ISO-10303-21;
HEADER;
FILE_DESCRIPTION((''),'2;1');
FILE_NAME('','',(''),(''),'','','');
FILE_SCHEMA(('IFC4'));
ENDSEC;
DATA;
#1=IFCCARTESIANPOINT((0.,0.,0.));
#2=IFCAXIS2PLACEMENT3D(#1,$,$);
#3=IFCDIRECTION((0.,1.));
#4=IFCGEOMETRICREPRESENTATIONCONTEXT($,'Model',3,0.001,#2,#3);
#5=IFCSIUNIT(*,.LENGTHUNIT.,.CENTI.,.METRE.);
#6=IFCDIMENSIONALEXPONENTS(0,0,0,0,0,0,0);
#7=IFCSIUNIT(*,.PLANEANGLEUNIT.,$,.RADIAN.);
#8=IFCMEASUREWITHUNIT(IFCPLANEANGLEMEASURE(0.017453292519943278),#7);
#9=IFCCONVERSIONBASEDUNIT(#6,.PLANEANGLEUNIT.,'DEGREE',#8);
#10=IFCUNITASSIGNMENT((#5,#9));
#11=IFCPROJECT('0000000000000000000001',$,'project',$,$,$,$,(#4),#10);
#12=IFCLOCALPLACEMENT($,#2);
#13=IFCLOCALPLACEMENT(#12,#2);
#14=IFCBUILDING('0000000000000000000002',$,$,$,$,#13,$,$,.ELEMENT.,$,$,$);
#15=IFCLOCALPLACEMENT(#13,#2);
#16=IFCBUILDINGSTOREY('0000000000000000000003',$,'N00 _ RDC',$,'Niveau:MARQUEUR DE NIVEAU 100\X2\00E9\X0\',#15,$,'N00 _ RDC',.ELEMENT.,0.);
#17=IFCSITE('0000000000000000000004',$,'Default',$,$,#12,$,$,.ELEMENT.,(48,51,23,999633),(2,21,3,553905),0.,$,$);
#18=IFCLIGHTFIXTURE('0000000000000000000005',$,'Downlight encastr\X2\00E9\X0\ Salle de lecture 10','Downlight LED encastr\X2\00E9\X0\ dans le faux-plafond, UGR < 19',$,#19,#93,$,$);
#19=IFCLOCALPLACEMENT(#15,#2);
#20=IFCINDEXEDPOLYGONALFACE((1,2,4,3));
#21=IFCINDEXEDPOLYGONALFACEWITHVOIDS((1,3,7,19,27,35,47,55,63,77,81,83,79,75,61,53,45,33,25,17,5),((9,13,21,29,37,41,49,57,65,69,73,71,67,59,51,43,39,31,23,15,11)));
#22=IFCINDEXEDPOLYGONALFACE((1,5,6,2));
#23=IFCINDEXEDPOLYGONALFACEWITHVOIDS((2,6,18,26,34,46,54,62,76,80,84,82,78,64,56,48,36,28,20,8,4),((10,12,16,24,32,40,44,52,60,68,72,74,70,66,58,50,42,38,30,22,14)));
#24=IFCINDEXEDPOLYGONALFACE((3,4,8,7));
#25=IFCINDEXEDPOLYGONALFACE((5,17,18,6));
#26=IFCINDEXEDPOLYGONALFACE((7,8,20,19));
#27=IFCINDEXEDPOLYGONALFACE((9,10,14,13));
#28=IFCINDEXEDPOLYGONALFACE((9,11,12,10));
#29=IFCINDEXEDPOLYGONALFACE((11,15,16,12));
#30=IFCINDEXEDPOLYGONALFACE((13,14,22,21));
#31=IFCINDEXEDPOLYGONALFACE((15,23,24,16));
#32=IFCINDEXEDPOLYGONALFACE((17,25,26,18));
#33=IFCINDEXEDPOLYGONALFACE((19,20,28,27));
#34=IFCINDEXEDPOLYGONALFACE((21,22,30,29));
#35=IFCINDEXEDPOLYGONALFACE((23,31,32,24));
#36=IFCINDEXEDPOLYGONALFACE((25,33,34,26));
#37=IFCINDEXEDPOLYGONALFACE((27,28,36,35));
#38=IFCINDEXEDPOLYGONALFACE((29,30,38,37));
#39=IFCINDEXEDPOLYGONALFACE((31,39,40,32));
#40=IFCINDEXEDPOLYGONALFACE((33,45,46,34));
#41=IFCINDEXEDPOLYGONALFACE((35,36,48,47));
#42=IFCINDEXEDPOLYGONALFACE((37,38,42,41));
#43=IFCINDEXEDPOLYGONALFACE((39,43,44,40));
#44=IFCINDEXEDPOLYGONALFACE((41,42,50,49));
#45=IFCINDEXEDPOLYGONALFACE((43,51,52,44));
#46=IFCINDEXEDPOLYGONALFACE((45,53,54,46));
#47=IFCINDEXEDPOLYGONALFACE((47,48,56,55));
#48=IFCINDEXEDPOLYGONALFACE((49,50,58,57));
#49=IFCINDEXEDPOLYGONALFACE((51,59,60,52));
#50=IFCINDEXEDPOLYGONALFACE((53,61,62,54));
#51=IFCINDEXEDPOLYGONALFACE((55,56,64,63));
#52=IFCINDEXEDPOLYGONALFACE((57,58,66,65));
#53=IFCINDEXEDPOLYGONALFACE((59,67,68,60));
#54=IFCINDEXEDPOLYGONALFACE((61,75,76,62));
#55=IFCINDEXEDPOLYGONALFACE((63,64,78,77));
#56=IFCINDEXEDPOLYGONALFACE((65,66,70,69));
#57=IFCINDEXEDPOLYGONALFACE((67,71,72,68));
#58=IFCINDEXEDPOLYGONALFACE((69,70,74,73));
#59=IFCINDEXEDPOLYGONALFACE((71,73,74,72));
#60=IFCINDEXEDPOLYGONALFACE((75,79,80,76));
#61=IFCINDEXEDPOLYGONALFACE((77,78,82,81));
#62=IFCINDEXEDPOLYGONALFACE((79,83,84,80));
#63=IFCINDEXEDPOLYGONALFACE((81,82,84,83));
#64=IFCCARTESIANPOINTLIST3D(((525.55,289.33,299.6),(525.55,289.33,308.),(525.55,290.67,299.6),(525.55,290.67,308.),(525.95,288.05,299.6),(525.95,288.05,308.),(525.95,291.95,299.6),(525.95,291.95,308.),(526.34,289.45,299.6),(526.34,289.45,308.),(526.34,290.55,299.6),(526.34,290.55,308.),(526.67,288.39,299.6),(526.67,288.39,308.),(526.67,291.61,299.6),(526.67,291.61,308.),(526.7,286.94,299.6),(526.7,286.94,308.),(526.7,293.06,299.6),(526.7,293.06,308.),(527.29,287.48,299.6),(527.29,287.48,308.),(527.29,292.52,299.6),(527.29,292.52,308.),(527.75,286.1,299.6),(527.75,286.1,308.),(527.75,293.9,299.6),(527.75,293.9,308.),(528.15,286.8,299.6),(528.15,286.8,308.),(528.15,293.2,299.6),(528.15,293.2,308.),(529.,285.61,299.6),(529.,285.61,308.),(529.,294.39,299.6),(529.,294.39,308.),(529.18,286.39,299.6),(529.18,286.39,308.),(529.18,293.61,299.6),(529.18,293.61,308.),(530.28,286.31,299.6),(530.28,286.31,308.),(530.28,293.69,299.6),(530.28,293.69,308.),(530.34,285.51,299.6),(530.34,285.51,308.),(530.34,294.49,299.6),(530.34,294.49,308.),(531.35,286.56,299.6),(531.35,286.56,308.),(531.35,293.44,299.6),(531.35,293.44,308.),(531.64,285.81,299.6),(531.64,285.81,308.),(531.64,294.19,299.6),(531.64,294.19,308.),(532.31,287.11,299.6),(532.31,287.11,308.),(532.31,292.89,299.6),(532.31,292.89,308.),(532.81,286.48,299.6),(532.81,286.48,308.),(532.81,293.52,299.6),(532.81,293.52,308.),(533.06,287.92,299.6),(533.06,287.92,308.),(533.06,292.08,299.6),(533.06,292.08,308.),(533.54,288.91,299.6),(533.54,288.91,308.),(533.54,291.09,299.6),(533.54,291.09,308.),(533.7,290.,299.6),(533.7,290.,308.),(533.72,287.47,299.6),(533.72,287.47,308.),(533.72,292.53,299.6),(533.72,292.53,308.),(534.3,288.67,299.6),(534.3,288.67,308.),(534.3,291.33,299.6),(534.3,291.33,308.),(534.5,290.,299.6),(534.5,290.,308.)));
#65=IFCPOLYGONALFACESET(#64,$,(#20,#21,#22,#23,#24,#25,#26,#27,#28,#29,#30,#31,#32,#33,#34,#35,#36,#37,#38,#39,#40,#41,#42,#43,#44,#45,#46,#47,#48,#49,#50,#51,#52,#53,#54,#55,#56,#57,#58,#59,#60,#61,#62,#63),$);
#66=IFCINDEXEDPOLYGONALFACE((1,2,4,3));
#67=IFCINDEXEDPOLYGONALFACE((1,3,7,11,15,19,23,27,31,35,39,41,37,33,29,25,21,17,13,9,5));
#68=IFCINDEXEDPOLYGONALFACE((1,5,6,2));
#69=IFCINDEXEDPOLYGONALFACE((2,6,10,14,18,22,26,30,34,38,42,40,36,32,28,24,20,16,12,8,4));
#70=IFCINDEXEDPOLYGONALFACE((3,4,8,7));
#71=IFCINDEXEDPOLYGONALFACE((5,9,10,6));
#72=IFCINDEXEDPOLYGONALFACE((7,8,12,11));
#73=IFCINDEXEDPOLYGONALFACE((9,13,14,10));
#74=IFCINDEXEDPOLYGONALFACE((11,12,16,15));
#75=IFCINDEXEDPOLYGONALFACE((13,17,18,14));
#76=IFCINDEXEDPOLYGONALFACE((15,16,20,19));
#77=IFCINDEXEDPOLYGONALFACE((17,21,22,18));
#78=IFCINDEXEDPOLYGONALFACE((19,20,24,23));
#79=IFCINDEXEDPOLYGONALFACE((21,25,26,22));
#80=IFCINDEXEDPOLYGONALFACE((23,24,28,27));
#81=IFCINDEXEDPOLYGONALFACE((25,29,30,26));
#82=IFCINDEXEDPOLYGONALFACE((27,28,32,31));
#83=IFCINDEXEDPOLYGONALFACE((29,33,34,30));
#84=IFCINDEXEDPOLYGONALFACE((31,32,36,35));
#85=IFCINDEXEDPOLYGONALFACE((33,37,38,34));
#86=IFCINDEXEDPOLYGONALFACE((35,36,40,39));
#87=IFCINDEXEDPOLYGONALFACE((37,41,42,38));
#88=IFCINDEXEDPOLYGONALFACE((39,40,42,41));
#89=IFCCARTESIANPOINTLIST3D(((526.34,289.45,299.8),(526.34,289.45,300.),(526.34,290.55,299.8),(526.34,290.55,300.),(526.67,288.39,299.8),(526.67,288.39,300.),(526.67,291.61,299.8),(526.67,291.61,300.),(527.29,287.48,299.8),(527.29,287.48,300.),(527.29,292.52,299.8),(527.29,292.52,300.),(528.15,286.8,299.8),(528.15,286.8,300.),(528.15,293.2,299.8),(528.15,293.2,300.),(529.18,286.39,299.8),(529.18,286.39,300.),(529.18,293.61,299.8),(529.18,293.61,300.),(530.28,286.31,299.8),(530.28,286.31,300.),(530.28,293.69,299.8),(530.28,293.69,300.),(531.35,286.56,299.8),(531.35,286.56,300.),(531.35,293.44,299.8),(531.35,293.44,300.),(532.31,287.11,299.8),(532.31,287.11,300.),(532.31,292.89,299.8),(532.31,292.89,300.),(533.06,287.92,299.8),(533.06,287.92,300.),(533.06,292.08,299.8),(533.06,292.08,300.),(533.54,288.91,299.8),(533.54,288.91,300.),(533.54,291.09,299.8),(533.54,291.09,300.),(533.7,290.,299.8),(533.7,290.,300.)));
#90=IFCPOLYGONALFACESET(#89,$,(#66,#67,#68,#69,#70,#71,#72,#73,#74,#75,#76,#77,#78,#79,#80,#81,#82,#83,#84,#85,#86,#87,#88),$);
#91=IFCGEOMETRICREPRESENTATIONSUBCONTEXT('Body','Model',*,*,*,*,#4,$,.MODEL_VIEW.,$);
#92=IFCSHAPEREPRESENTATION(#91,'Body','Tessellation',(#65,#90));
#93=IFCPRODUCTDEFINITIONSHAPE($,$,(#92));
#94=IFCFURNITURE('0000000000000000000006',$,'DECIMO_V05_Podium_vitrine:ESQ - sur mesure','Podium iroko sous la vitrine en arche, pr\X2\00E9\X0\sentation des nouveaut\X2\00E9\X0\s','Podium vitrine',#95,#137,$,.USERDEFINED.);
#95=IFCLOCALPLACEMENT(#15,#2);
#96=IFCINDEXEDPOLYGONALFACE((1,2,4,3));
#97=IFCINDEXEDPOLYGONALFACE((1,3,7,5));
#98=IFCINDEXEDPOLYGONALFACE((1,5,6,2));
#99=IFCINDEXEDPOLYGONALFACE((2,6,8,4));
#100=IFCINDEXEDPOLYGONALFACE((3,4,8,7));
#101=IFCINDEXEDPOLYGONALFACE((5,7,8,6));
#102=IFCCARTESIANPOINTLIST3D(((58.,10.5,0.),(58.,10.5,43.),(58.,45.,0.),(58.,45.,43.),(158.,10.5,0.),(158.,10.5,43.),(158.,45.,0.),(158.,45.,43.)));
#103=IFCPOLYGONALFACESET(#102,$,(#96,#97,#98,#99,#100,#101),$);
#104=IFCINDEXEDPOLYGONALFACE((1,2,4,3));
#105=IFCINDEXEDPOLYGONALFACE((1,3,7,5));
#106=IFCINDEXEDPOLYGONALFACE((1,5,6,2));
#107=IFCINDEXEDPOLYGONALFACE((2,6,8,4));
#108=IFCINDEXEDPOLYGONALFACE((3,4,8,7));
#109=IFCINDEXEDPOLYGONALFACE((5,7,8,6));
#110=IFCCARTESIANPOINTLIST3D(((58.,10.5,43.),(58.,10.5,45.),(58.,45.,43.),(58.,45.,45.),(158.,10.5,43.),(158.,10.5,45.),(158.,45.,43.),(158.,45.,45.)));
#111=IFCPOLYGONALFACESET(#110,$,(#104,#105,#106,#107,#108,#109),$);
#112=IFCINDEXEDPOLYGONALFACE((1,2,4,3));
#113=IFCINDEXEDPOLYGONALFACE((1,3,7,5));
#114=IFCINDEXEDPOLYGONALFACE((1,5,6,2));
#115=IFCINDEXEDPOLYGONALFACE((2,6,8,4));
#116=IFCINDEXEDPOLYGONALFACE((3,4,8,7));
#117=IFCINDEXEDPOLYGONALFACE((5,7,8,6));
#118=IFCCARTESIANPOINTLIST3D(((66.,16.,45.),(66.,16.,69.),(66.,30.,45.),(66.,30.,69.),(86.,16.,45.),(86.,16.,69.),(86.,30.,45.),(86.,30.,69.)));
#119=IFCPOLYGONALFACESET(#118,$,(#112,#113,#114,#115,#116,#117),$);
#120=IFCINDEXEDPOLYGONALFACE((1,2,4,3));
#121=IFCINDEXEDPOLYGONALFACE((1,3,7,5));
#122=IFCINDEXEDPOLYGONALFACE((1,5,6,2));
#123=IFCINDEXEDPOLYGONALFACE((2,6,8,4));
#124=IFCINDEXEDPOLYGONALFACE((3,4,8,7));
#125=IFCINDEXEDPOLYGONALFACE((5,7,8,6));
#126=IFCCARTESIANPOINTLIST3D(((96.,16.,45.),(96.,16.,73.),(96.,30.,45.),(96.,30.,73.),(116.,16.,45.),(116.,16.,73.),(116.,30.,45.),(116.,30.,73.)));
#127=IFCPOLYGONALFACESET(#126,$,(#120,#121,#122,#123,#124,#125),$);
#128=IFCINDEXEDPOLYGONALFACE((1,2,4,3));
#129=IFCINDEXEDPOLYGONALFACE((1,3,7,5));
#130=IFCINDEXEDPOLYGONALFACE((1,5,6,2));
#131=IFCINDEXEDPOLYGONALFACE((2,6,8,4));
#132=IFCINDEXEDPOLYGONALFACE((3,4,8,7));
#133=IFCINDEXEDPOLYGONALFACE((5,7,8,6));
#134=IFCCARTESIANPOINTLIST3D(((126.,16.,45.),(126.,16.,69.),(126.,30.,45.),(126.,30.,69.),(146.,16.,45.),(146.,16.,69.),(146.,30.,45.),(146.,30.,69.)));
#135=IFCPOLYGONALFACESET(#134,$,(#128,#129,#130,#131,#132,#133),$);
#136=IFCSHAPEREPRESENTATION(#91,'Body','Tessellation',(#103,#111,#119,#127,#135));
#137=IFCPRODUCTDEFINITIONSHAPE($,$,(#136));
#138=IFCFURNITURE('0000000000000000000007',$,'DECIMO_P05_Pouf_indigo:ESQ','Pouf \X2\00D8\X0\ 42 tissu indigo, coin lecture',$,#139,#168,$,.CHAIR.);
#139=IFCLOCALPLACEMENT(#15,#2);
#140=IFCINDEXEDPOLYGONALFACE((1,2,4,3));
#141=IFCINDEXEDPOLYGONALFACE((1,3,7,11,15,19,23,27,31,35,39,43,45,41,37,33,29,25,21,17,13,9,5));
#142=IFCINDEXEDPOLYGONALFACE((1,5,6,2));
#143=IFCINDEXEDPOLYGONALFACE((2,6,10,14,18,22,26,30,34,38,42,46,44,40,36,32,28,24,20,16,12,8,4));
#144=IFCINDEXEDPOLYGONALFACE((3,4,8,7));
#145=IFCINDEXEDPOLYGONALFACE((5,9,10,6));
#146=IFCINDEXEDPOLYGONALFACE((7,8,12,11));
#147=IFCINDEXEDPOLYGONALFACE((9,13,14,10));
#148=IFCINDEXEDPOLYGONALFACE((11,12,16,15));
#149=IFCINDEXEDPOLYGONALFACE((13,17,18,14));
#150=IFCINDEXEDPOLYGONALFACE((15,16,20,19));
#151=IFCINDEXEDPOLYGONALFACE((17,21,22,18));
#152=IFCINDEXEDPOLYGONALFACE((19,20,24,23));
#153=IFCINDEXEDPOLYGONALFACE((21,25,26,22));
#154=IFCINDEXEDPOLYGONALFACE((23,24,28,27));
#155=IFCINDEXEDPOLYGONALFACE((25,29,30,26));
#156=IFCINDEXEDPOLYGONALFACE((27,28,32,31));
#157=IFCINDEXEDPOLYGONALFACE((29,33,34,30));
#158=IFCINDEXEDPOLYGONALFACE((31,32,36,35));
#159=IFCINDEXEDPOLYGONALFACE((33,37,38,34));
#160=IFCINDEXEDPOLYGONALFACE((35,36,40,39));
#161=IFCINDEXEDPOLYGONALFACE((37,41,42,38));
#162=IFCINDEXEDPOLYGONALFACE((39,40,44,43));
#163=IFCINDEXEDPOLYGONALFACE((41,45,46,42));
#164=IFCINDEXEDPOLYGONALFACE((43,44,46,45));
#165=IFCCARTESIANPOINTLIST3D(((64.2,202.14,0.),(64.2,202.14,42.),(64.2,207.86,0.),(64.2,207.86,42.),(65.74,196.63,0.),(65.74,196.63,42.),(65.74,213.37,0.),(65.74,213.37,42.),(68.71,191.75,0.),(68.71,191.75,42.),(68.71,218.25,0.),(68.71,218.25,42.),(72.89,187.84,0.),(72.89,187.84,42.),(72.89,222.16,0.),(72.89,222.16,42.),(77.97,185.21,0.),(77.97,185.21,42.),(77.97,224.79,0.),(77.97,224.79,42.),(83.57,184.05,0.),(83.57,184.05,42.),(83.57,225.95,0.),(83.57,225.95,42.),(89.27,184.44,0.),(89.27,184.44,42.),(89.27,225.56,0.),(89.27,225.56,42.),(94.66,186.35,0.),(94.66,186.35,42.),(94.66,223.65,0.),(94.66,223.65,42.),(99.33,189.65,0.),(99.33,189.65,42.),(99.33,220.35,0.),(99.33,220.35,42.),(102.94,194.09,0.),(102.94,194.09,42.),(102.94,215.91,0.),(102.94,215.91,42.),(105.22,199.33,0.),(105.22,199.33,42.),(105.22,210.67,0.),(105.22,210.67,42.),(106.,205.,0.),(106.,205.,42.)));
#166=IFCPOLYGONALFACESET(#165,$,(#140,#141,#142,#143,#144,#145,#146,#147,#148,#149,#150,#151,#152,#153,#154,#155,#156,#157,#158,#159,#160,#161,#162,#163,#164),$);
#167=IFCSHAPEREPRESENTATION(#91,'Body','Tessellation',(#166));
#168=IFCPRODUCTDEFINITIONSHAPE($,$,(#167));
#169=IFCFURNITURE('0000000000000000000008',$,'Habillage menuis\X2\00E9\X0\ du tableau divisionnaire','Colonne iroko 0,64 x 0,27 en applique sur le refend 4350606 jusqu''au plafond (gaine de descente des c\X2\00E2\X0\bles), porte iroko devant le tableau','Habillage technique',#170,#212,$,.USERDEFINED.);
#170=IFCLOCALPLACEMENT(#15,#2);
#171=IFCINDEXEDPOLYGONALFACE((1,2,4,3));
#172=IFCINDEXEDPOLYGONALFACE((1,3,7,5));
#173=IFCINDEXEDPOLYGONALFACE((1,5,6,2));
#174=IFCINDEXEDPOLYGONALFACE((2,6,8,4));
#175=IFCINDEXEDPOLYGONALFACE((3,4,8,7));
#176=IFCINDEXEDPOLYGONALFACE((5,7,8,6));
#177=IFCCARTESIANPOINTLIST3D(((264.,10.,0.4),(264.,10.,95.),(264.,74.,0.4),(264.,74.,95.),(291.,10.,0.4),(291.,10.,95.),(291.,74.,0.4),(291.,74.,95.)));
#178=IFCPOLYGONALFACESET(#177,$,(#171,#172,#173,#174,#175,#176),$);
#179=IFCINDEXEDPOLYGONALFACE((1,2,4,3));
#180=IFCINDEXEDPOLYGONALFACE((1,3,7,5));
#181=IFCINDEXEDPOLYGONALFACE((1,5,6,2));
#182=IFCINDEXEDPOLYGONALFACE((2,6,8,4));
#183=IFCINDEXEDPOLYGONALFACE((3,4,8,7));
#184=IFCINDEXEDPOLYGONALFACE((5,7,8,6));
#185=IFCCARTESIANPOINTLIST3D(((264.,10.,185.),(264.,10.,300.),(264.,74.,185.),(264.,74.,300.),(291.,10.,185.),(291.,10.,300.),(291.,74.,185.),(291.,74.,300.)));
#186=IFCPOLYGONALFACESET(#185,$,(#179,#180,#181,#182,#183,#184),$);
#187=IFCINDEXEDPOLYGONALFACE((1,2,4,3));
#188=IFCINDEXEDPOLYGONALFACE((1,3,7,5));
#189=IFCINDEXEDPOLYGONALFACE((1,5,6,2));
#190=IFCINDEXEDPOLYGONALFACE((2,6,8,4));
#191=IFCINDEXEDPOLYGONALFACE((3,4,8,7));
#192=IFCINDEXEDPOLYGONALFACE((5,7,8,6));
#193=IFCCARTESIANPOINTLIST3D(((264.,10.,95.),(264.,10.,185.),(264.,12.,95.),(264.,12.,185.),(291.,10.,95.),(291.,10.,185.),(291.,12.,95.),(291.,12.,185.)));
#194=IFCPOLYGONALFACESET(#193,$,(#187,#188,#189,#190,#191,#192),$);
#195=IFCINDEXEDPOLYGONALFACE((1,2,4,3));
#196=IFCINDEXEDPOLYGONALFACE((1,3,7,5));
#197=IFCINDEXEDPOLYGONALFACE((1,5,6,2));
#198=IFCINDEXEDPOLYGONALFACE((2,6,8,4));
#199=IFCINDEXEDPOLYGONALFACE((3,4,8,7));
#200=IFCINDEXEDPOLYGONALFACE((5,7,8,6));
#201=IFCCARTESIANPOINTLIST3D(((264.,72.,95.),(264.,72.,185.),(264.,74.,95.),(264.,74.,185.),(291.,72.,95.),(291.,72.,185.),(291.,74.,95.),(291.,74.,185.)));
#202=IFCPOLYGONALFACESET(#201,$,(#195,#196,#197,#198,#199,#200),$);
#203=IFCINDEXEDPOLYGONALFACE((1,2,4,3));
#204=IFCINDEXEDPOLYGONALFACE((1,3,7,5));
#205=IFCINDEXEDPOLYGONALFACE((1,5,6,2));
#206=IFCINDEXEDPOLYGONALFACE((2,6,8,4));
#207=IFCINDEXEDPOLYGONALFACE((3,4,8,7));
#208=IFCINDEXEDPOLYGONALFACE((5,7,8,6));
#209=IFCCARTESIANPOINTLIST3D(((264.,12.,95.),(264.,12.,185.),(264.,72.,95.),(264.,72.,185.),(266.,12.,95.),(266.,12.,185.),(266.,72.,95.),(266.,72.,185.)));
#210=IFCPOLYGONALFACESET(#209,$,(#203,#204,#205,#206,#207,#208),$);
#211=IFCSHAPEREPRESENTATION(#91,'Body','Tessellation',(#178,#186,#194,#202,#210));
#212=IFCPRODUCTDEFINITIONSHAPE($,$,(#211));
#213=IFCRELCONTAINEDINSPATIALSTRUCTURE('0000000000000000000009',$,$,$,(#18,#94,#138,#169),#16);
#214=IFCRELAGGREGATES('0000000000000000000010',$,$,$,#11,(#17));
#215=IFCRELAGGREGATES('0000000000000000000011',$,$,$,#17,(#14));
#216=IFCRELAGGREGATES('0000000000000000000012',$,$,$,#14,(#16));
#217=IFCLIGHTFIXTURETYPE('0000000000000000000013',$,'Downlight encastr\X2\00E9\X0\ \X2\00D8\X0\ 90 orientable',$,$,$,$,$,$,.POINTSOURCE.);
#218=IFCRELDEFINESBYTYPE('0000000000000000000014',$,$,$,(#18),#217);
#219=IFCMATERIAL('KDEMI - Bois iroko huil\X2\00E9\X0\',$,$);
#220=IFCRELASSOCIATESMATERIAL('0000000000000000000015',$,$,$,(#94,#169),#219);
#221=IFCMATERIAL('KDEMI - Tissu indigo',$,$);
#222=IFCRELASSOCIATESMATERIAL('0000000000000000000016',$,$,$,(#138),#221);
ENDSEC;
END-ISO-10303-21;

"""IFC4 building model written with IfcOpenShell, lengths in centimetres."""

from ifc_helpers import new_model, entity, si_unit, converted_unit, direction, frame, frame_2d, origin, origin_with_axes, place, context, subcontext, project, spatial, rectangle, circle, hollow_circle, extrude, material, type_object, element, save


model = new_model("IFC4")

# Units and contexts
model_context = context("Model", 3, precision=0.001, world=origin(), true_north=direction((0.0, 1.0)))
body_context = subcontext(model_context, "Body", "Model", "MODEL_VIEW")
ifc_project = project(units=[si_unit("LENGTHUNIT", "METRE", prefix="CENTI"), converted_unit("PLANEANGLEUNIT", "DEGREE", entity("IfcPlaneAngleMeasure", 0.017453292519943278), si_unit("PLANEANGLEUNIT", "RADIAN"), dimensions=[0, 0, 0, 0, 0, 0, 0])], contexts=[model_context])

# Site, building, storey
site_placement = place(None, origin())
site = spatial("IfcSite", under=ifc_project, at=site_placement, Name="Default", CompositionType="ELEMENT", RefLatitude=(48, 51, 23, 999633), RefLongitude=(2, 21, 3, 553905), RefElevation=0.0)
building_placement = place(site_placement, origin())
building = spatial("IfcBuilding", under=site, at=building_placement, CompositionType="ELEMENT")
storey_placement = place(building_placement, origin())
storey = spatial("IfcBuildingStorey", under=building, at=storey_placement, Name="N00 _ RDC", ObjectType="Niveau:MARQUEUR DE NIVEAU 100é", LongName="N00 _ RDC", CompositionType="ELEMENT", Elevation=0.0)

# Light fixture
light_fixture_type_1 = type_object("IfcLightFixtureType", Name="Downlight encastré Ø 90 orientable", PredefinedType="POINTSOURCE")
light_fixture_1_placement = place(storey_placement, origin_with_axes())
element("IfcLightFixture", 1, at=light_fixture_1_placement, inside=storey, type_object=light_fixture_type_1, Name="Downlight encastré Salle de lecture 10", Description="Downlight LED encastré dans le faux-plafond, UGR < 19", context=body_context, shape_type="SweptSolid", body=[
    extrude(hollow_circle(Radius=4.5, WallThickness=0.8, at=frame_2d((530.0, 290.0))), frame((0.0, 0.0, 299.6)), (0.0, 0.0, 1.0), 8.4),
    extrude(circle(Radius=3.7, at=frame_2d((530.0, 290.0))), frame((0.0, 0.0, 299.8)), (0.0, 0.0, 1.0), 0.2),
])

# Furniture
ifc_material_1 = material(Name="KDEMI - Bois iroko huilé")
furniture_1_placement = place(storey_placement, origin_with_axes())
element("IfcFurniture", 2, at=furniture_1_placement, inside=storey, material=ifc_material_1, Name="DECIMO_V05_Podium_vitrine:ESQ - sur mesure", Description="Podium iroko sous la vitrine en arche, présentation des nouveautés", ObjectType="Podium vitrine", PredefinedType="USERDEFINED", context=body_context, shape_type="SweptSolid", body=[
    extrude(rectangle(XDim=100.0, YDim=34.5, at=frame_2d((108.0, 27.75))), origin(), (0.0, 0.0, 1.0), 43.0),
    extrude(rectangle(XDim=100.0, YDim=34.5, at=frame_2d((108.0, 27.75))), frame((0.0, 0.0, 43.0)), (0.0, 0.0, 1.0), 2.0),
    extrude(rectangle(XDim=20.0, YDim=14.0, at=frame_2d((76.0, 23.0))), frame((0.0, 0.0, 45.0)), (0.0, 0.0, 1.0), 24.0),
    extrude(rectangle(XDim=20.0, YDim=14.0, at=frame_2d((106.0, 23.0))), frame((0.0, 0.0, 45.0)), (0.0, 0.0, 1.0), 28.0),
    extrude(rectangle(XDim=20.0, YDim=14.0, at=frame_2d((136.0, 23.0))), frame((0.0, 0.0, 45.0)), (0.0, 0.0, 1.0), 24.0),
])
ifc_material_2 = material(Name="KDEMI - Tissu indigo")
furniture_2_placement = place(storey_placement, origin_with_axes())
element("IfcFurniture", 3, at=furniture_2_placement, inside=storey, material=ifc_material_2, Name="DECIMO_P05_Pouf_indigo:ESQ", Description="Pouf Ø 42 tissu indigo, coin lecture", PredefinedType="CHAIR", context=body_context, shape_type="SweptSolid", body=[
    extrude(circle(Radius=21.0, at=frame_2d((85.0, 205.0))), origin(), (0.0, 0.0, 1.0), 42.0),
])
furniture_3_placement = place(storey_placement, origin_with_axes())
element("IfcFurniture", 4, at=furniture_3_placement, inside=storey, material=ifc_material_1, Name="Habillage menuisé du tableau divisionnaire", Description="Colonne iroko 0,64 x 0,27 en applique sur le refend 4350606 jusqu'au plafond (gaine de descente des câbles), porte iroko devant le tableau", ObjectType="Habillage technique", PredefinedType="USERDEFINED", context=body_context, shape_type="SweptSolid", body=[
    extrude(rectangle(XDim=27.0, YDim=64.0, at=frame_2d((277.5, 42.0))), frame((0.0, 0.0, 0.4)), (0.0, 0.0, 1.0), 94.6),
    extrude(rectangle(XDim=27.0, YDim=64.0, at=frame_2d((277.5, 42.0))), frame((0.0, 0.0, 185.0)), (0.0, 0.0, 1.0), 115.0),
    extrude(rectangle(XDim=27.0, YDim=2.0, at=frame_2d((277.5, 11.0))), frame((0.0, 0.0, 95.0)), (0.0, 0.0, 1.0), 90.0),
    extrude(rectangle(XDim=27.0, YDim=2.0, at=frame_2d((277.5, 73.0))), frame((0.0, 0.0, 95.0)), (0.0, 0.0, 1.0), 90.0),
    extrude(rectangle(XDim=2.0, YDim=60.0, at=frame_2d((265.0, 42.0))), frame((0.0, 0.0, 95.0)), (0.0, 0.0, 1.0), 90.0),
])

save(model, "model.ifc")
